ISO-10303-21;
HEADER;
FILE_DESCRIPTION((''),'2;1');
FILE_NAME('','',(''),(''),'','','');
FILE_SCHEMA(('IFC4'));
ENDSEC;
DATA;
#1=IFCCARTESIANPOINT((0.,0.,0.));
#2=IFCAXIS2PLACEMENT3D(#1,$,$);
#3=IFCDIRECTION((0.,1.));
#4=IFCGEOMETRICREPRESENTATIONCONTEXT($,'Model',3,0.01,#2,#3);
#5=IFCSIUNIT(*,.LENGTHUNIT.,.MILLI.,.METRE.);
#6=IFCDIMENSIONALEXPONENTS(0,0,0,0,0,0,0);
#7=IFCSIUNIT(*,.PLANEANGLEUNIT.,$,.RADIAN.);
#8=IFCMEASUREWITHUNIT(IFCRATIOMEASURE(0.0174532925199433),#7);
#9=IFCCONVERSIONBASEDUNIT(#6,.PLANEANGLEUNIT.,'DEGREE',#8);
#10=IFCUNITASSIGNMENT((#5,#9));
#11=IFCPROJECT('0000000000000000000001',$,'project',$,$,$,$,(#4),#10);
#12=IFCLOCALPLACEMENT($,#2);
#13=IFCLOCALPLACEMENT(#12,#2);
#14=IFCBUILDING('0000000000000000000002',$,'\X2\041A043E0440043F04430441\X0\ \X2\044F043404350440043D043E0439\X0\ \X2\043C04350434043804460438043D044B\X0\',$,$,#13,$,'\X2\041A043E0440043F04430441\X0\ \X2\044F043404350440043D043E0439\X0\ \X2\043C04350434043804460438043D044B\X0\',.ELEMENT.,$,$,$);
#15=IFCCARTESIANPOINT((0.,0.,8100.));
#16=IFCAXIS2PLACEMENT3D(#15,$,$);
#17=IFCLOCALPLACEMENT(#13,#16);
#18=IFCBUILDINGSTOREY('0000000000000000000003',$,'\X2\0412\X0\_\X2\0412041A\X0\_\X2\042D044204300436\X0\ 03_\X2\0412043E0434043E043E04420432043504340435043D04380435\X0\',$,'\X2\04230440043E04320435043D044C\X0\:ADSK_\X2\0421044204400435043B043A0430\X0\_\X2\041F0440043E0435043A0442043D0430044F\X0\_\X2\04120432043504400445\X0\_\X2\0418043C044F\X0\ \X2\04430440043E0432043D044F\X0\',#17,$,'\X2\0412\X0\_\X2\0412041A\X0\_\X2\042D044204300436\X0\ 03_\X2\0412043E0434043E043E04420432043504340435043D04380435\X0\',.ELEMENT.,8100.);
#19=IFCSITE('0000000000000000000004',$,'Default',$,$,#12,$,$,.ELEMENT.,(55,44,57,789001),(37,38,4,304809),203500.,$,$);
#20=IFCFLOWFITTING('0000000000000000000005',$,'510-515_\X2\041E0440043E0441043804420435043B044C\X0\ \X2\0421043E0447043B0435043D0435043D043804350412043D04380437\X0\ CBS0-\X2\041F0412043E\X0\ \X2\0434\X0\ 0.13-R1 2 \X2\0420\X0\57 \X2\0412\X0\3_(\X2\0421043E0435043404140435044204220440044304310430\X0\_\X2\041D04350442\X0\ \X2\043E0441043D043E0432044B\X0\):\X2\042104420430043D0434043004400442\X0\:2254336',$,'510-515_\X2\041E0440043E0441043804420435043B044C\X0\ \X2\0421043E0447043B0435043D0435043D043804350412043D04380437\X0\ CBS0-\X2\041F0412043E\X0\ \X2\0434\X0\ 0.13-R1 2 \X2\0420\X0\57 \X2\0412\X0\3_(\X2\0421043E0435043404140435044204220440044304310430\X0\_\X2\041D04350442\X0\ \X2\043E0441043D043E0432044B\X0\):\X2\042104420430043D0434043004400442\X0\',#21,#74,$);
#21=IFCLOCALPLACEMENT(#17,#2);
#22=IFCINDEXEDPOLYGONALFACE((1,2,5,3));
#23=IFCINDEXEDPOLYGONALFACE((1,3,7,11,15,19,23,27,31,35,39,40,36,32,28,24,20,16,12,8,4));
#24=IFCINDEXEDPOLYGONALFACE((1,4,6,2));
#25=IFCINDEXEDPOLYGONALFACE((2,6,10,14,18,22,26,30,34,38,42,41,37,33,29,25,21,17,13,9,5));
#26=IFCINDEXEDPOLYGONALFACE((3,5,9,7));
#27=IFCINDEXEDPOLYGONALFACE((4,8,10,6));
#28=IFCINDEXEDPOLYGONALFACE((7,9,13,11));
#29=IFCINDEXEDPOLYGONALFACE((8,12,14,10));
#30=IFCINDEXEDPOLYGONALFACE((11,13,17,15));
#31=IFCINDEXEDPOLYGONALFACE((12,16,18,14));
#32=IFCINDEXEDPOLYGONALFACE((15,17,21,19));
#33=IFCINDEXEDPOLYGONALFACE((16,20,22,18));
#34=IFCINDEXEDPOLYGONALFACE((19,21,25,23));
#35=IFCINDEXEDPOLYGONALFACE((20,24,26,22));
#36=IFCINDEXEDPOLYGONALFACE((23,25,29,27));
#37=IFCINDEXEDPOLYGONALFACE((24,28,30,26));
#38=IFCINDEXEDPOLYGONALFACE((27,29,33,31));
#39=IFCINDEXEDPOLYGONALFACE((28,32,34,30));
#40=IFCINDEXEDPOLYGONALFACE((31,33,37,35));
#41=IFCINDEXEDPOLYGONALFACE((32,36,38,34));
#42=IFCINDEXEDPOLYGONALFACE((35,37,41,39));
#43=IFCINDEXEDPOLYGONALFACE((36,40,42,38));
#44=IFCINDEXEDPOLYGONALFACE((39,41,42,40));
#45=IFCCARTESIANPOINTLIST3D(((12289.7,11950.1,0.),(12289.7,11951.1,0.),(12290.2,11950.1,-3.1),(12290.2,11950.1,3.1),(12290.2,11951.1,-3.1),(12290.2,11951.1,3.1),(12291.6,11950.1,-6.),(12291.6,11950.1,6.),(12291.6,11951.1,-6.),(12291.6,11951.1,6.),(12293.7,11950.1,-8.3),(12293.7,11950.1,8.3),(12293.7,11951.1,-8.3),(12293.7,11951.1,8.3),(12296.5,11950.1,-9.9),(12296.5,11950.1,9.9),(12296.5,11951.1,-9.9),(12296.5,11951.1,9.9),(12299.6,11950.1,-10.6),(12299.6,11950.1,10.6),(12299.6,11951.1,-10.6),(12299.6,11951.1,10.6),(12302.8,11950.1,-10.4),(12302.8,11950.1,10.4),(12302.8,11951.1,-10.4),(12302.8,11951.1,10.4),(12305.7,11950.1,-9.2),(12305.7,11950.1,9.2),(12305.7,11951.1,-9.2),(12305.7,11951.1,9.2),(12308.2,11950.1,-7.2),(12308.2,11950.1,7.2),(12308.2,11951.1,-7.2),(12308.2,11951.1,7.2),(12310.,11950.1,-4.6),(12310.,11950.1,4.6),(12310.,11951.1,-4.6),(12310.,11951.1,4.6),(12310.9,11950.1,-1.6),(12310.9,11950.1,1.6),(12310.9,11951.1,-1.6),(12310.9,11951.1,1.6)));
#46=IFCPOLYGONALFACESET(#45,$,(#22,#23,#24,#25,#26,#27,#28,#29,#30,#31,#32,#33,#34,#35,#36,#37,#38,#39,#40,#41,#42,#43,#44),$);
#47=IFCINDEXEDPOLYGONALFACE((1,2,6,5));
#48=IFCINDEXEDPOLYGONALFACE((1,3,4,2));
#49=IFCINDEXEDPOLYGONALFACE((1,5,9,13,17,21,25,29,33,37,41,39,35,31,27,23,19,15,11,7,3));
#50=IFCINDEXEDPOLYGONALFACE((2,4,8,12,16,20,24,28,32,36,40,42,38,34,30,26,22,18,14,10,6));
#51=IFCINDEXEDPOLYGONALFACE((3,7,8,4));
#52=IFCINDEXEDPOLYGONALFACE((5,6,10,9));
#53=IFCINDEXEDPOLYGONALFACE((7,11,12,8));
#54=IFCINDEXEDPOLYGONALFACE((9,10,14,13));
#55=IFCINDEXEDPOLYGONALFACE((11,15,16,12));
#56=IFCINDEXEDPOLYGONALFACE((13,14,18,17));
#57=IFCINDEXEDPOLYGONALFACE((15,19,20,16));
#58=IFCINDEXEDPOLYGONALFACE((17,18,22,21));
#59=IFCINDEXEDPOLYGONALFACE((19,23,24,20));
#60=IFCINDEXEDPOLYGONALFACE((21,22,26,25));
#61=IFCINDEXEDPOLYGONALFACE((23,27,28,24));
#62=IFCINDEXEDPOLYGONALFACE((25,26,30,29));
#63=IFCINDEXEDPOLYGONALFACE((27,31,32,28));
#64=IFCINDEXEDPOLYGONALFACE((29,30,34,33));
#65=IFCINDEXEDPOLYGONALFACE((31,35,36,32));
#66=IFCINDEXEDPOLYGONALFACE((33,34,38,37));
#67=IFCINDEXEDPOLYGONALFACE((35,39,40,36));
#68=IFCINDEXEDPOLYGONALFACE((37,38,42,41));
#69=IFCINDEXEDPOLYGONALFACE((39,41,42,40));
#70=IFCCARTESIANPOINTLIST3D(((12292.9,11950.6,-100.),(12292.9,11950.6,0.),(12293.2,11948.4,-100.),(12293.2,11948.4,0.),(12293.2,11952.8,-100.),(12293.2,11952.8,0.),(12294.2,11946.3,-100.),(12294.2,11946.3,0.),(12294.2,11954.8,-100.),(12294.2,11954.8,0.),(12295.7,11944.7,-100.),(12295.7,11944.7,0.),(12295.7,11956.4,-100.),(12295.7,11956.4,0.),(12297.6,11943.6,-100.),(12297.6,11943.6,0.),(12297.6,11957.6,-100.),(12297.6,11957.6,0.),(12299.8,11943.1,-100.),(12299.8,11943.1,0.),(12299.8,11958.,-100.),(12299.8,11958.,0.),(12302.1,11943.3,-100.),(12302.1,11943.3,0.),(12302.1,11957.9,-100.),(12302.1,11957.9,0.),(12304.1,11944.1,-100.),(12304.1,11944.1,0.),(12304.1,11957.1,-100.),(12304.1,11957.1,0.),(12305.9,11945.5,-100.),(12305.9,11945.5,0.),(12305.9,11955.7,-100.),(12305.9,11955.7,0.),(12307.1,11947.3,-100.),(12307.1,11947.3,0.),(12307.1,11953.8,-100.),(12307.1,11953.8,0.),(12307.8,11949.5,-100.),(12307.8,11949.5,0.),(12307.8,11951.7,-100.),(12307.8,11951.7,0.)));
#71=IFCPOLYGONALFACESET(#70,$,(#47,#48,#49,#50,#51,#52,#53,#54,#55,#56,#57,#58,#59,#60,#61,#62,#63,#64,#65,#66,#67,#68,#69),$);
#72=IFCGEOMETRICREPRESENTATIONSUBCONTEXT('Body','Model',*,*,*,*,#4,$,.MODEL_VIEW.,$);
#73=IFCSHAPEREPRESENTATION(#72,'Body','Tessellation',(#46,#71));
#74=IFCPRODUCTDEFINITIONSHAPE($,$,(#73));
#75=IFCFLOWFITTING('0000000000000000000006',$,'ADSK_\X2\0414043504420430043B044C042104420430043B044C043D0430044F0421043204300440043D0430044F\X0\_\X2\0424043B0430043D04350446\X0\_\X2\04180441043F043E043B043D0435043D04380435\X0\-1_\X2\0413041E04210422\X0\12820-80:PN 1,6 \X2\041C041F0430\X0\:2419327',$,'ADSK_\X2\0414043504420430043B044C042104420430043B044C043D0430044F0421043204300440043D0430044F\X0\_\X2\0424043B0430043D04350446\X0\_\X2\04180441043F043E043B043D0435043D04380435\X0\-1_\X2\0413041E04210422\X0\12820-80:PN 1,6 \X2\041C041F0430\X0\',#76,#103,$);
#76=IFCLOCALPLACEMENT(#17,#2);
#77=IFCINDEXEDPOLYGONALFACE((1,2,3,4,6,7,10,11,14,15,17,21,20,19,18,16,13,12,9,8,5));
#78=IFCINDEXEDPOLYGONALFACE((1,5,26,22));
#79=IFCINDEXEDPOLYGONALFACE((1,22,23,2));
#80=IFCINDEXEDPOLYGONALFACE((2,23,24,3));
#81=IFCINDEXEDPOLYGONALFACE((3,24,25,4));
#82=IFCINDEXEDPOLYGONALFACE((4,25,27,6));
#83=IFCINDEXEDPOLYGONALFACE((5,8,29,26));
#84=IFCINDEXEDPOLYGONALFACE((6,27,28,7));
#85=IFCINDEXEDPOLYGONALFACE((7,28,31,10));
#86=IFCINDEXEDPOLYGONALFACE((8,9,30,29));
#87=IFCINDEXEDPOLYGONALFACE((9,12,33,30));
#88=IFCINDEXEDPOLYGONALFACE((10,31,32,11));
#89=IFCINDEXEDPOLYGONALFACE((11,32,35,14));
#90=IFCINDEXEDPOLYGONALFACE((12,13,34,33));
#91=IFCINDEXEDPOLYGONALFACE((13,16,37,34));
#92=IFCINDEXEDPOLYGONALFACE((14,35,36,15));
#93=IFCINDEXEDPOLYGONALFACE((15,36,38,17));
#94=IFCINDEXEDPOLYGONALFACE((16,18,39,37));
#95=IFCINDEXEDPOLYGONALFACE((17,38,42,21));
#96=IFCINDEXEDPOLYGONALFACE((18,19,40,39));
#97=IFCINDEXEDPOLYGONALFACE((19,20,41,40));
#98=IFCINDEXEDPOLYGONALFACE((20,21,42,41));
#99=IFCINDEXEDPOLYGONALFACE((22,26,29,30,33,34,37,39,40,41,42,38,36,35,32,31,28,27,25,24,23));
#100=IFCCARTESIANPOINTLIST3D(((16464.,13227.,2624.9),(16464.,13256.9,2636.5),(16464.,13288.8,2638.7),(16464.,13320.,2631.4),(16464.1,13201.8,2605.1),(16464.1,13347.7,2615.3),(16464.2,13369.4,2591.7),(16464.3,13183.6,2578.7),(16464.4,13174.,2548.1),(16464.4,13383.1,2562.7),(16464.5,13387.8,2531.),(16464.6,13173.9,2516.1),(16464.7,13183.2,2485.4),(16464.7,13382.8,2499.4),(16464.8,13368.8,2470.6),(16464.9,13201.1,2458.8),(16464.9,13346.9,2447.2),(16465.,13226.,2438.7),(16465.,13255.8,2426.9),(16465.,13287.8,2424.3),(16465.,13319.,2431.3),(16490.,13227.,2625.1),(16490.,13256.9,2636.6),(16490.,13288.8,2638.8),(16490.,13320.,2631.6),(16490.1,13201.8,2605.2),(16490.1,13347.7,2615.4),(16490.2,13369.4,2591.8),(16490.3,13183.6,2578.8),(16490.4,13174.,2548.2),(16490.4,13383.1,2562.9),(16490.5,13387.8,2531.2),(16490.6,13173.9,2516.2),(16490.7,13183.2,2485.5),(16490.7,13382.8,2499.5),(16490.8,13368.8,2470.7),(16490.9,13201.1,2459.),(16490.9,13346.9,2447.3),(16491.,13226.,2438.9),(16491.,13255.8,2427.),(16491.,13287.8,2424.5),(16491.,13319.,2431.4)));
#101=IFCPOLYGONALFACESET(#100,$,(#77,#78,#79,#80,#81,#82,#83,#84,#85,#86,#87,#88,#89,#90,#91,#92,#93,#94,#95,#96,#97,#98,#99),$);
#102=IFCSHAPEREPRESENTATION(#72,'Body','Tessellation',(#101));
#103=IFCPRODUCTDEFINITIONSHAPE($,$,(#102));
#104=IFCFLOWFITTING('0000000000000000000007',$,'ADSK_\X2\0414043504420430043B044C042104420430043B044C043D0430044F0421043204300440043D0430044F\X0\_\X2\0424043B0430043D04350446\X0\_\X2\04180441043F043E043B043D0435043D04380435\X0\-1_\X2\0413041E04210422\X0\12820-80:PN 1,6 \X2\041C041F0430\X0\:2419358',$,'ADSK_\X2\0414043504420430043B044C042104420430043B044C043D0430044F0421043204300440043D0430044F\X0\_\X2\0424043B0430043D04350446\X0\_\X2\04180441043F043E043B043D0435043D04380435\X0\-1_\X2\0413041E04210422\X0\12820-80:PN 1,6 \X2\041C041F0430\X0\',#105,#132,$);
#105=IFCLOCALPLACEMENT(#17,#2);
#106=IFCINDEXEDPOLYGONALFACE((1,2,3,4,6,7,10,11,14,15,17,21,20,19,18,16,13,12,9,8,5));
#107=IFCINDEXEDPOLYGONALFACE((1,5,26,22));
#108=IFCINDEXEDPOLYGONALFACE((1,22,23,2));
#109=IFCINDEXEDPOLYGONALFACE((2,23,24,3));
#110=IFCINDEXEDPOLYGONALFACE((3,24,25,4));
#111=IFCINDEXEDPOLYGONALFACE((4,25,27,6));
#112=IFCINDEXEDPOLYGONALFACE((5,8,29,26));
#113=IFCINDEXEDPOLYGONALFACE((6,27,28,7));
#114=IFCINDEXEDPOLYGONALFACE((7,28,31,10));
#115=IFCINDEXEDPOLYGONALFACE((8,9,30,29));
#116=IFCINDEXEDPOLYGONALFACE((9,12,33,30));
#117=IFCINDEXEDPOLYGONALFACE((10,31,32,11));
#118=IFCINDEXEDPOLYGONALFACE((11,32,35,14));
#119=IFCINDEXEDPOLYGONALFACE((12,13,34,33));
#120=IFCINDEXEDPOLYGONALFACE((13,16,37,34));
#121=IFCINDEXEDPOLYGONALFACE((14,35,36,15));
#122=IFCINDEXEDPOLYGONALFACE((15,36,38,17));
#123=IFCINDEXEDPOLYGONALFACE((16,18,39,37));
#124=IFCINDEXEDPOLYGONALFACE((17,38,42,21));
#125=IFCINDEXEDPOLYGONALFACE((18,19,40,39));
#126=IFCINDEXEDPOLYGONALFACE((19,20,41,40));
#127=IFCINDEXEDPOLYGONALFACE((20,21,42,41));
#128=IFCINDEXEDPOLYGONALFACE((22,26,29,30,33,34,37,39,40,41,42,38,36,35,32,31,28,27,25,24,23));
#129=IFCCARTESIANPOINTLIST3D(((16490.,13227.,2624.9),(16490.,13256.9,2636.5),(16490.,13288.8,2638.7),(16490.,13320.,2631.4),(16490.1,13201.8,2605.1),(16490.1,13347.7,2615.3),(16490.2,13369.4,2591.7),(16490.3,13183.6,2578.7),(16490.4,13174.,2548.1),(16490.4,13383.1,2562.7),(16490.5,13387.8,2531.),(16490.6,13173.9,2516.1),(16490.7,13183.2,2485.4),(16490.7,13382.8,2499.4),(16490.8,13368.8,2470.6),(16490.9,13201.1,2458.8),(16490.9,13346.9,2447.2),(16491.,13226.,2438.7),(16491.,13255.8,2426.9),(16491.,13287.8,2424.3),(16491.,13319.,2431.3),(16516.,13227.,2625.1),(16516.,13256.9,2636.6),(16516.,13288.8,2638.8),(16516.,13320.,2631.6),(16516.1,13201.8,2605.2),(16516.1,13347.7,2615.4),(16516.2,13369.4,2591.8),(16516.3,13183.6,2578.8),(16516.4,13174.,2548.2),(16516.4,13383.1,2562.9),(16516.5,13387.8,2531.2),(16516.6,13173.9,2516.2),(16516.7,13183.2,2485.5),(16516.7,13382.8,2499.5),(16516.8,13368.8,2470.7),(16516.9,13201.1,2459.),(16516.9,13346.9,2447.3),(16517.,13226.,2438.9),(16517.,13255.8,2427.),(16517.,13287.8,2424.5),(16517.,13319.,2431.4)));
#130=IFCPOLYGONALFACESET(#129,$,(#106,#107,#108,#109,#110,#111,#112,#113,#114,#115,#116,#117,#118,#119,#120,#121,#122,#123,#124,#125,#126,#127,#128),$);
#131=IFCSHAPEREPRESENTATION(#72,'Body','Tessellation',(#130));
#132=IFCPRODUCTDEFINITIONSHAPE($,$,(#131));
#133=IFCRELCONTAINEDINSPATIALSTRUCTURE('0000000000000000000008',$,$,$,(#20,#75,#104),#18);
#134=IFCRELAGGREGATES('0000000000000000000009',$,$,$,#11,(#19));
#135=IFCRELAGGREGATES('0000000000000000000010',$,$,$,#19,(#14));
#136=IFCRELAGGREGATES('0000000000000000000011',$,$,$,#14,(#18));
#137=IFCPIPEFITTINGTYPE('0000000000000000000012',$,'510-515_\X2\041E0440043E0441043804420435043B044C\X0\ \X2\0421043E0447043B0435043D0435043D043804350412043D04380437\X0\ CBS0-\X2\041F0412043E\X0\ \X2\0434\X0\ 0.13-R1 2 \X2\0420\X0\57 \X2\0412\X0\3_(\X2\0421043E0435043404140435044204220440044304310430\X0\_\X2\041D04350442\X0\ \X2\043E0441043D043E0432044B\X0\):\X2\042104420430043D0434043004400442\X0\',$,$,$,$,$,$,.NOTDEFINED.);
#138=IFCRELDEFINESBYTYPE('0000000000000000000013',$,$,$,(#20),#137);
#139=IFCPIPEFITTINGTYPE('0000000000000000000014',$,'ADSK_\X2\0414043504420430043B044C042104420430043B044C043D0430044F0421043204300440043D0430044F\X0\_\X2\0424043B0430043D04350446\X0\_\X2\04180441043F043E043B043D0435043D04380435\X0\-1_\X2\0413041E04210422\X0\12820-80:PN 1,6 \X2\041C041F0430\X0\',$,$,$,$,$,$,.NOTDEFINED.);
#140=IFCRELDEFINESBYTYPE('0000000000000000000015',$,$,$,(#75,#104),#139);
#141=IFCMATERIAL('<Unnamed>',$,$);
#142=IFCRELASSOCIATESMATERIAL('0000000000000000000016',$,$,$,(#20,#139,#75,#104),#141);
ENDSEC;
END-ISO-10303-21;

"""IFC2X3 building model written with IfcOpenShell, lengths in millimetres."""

from ifc_helpers import new_model, entity, si_unit, converted_unit, direction, frame, origin, origin_2d_with_axis, place, context, subcontext, project, spatial, circle, extrude, source, transform, mapped, material, type_object, type_shapes, element, save


model = new_model("IFC2X3")

# Units and contexts
model_context = context("Model", 3, precision=0.01, world=origin(), true_north=direction((0.0, 1.0)))
body_context = subcontext(model_context, "Body", "Model", "MODEL_VIEW")
ifc_project = project(units=[si_unit("LENGTHUNIT", "METRE", prefix="MILLI"), converted_unit("PLANEANGLEUNIT", "DEGREE", entity("IfcRatioMeasure", 0.0174532925199433), si_unit("PLANEANGLEUNIT", "RADIAN"), dimensions=[0, 0, 0, 0, 0, 0, 0])], contexts=[model_context])

# Site, building, storey
site_placement = place(None, origin())
site = spatial("IfcSite", under=ifc_project, at=site_placement, Name="Default", CompositionType="ELEMENT", RefLatitude=(55, 44, 57, 789001), RefLongitude=(37, 38, 4, 304809), RefElevation=203500.0)
building_placement = place(site_placement, origin())
building = spatial("IfcBuilding", under=site, at=building_placement, Name="Корпус ядерной медицины", LongName="Корпус ядерной медицины", CompositionType="ELEMENT")
storey_placement = place(building_placement, frame((0.0, 0.0, 8100.0)))
storey = spatial("IfcBuildingStorey", under=building, at=storey_placement, Name="В_ВК_Этаж 03_Водоотведение", ObjectType="Уровень:ADSK_Стрелка_Проектная_Вверх_Имя уровня", LongName="В_ВК_Этаж 03_Водоотведение", CompositionType="ELEMENT", Elevation=8100.0)

# Flow fittings
ifc_material_1 = material(Name="<Unnamed>")
pipe_fitting_type_1 = type_object("IfcPipeFittingType", Name="510-515_Ороситель СочленениеВниз CBS0-ПВо д 0.13-R1 2 Р57 В3_(СоедДетТруба_Нет основы):Стандарт", PredefinedType="NOTDEFINED")
shared_shape_1 = source(origin(), body_context, "Body", "SweptSolid", [
    extrude(circle(Radius=10.7, at=origin_2d_with_axis()), frame((-0.5, 0.0, 0.0), z_axis=(1.0, 0.0, 0.0), x_axis=(0.0, 1.0, 0.0)), (0.0, 0.0, 1.0), 1.0),
    extrude(circle(Radius=7.5, at=origin_2d_with_axis()), frame((0.0, 0.0, -100.0), z_axis=(0.0, 0.0, 1.0), x_axis=(0.0, 1.0, 0.0)), (0.0, 0.0, 1.0), 100.0),
])
type_shapes(pipe_fitting_type_1, [shared_shape_1])
for number, where, z_axis, x_axis, name in (
    (1, (12300.4, 11950.6, 0.0), (0.0, 0.0, 1.0), (0.0, 1.0, 0.0), "510-515_Ороситель СочленениеВниз CBS0-ПВо д 0.13-R1 2 Р57 В3_(СоедДетТруба_Нет основы):Стандарт:2254336"),
):
    element("IfcFlowFitting", number, at=place(storey_placement, frame(where, z_axis=z_axis, x_axis=x_axis)), inside=storey, type_object=pipe_fitting_type_1, material=ifc_material_1, Name=name, ObjectType="510-515_Ороситель СочленениеВниз CBS0-ПВо д 0.13-R1 2 Р57 В3_(СоедДетТруба_Нет основы):Стандарт", context=body_context, shape_type="MappedRepresentation", body=[
        mapped(shared_shape_1, transform((0.0, 0.0, 0.0), scale=1.0)),
    ])
pipe_fitting_type_2 = type_object("IfcPipeFittingType", Name="ADSK_ДетальСтальнаяСварная_Фланец_Исполнение-1_ГОСТ12820-80:PN 1,6 МПа", PredefinedType="NOTDEFINED", material=ifc_material_1)
shared_shape_2 = source(origin(), body_context, "Body", "SweptSolid", [
    extrude(circle(Radius=107.5, at=origin_2d_with_axis()), frame((0.0, 0.0, 0.0), z_axis=(1.0, 0.0, 0.0), x_axis=(0.0, 1.0, 0.0)), (0.0, 0.0, 1.0), 26.0),
])
type_shapes(pipe_fitting_type_2, [shared_shape_2])
for number, where, z_axis, x_axis, name in (
    (2, (16464.5, 13280.3, 2531.6), (-0.005, 0.005, 0.999975), (0.999988, 0.0, 0.005), "ADSK_ДетальСтальнаяСварная_Фланец_Исполнение-1_ГОСТ12820-80:PN 1,6 МПа:2419327"),
    (3, (16490.5, 13280.3, 2531.6), (-0.005, 0.005, 0.999975), (0.999988, 0.0, 0.005), "ADSK_ДетальСтальнаяСварная_Фланец_Исполнение-1_ГОСТ12820-80:PN 1,6 МПа:2419358"),
):
    element("IfcFlowFitting", number, at=place(storey_placement, frame(where, z_axis=z_axis, x_axis=x_axis)), inside=storey, type_object=pipe_fitting_type_2, material=ifc_material_1, Name=name, ObjectType="ADSK_ДетальСтальнаяСварная_Фланец_Исполнение-1_ГОСТ12820-80:PN 1,6 МПа", context=body_context, shape_type="MappedRepresentation", body=[
        mapped(shared_shape_2, transform((0.0, 0.0, 0.0), scale=1.0)),
    ])

save(model, "model.ifc")
